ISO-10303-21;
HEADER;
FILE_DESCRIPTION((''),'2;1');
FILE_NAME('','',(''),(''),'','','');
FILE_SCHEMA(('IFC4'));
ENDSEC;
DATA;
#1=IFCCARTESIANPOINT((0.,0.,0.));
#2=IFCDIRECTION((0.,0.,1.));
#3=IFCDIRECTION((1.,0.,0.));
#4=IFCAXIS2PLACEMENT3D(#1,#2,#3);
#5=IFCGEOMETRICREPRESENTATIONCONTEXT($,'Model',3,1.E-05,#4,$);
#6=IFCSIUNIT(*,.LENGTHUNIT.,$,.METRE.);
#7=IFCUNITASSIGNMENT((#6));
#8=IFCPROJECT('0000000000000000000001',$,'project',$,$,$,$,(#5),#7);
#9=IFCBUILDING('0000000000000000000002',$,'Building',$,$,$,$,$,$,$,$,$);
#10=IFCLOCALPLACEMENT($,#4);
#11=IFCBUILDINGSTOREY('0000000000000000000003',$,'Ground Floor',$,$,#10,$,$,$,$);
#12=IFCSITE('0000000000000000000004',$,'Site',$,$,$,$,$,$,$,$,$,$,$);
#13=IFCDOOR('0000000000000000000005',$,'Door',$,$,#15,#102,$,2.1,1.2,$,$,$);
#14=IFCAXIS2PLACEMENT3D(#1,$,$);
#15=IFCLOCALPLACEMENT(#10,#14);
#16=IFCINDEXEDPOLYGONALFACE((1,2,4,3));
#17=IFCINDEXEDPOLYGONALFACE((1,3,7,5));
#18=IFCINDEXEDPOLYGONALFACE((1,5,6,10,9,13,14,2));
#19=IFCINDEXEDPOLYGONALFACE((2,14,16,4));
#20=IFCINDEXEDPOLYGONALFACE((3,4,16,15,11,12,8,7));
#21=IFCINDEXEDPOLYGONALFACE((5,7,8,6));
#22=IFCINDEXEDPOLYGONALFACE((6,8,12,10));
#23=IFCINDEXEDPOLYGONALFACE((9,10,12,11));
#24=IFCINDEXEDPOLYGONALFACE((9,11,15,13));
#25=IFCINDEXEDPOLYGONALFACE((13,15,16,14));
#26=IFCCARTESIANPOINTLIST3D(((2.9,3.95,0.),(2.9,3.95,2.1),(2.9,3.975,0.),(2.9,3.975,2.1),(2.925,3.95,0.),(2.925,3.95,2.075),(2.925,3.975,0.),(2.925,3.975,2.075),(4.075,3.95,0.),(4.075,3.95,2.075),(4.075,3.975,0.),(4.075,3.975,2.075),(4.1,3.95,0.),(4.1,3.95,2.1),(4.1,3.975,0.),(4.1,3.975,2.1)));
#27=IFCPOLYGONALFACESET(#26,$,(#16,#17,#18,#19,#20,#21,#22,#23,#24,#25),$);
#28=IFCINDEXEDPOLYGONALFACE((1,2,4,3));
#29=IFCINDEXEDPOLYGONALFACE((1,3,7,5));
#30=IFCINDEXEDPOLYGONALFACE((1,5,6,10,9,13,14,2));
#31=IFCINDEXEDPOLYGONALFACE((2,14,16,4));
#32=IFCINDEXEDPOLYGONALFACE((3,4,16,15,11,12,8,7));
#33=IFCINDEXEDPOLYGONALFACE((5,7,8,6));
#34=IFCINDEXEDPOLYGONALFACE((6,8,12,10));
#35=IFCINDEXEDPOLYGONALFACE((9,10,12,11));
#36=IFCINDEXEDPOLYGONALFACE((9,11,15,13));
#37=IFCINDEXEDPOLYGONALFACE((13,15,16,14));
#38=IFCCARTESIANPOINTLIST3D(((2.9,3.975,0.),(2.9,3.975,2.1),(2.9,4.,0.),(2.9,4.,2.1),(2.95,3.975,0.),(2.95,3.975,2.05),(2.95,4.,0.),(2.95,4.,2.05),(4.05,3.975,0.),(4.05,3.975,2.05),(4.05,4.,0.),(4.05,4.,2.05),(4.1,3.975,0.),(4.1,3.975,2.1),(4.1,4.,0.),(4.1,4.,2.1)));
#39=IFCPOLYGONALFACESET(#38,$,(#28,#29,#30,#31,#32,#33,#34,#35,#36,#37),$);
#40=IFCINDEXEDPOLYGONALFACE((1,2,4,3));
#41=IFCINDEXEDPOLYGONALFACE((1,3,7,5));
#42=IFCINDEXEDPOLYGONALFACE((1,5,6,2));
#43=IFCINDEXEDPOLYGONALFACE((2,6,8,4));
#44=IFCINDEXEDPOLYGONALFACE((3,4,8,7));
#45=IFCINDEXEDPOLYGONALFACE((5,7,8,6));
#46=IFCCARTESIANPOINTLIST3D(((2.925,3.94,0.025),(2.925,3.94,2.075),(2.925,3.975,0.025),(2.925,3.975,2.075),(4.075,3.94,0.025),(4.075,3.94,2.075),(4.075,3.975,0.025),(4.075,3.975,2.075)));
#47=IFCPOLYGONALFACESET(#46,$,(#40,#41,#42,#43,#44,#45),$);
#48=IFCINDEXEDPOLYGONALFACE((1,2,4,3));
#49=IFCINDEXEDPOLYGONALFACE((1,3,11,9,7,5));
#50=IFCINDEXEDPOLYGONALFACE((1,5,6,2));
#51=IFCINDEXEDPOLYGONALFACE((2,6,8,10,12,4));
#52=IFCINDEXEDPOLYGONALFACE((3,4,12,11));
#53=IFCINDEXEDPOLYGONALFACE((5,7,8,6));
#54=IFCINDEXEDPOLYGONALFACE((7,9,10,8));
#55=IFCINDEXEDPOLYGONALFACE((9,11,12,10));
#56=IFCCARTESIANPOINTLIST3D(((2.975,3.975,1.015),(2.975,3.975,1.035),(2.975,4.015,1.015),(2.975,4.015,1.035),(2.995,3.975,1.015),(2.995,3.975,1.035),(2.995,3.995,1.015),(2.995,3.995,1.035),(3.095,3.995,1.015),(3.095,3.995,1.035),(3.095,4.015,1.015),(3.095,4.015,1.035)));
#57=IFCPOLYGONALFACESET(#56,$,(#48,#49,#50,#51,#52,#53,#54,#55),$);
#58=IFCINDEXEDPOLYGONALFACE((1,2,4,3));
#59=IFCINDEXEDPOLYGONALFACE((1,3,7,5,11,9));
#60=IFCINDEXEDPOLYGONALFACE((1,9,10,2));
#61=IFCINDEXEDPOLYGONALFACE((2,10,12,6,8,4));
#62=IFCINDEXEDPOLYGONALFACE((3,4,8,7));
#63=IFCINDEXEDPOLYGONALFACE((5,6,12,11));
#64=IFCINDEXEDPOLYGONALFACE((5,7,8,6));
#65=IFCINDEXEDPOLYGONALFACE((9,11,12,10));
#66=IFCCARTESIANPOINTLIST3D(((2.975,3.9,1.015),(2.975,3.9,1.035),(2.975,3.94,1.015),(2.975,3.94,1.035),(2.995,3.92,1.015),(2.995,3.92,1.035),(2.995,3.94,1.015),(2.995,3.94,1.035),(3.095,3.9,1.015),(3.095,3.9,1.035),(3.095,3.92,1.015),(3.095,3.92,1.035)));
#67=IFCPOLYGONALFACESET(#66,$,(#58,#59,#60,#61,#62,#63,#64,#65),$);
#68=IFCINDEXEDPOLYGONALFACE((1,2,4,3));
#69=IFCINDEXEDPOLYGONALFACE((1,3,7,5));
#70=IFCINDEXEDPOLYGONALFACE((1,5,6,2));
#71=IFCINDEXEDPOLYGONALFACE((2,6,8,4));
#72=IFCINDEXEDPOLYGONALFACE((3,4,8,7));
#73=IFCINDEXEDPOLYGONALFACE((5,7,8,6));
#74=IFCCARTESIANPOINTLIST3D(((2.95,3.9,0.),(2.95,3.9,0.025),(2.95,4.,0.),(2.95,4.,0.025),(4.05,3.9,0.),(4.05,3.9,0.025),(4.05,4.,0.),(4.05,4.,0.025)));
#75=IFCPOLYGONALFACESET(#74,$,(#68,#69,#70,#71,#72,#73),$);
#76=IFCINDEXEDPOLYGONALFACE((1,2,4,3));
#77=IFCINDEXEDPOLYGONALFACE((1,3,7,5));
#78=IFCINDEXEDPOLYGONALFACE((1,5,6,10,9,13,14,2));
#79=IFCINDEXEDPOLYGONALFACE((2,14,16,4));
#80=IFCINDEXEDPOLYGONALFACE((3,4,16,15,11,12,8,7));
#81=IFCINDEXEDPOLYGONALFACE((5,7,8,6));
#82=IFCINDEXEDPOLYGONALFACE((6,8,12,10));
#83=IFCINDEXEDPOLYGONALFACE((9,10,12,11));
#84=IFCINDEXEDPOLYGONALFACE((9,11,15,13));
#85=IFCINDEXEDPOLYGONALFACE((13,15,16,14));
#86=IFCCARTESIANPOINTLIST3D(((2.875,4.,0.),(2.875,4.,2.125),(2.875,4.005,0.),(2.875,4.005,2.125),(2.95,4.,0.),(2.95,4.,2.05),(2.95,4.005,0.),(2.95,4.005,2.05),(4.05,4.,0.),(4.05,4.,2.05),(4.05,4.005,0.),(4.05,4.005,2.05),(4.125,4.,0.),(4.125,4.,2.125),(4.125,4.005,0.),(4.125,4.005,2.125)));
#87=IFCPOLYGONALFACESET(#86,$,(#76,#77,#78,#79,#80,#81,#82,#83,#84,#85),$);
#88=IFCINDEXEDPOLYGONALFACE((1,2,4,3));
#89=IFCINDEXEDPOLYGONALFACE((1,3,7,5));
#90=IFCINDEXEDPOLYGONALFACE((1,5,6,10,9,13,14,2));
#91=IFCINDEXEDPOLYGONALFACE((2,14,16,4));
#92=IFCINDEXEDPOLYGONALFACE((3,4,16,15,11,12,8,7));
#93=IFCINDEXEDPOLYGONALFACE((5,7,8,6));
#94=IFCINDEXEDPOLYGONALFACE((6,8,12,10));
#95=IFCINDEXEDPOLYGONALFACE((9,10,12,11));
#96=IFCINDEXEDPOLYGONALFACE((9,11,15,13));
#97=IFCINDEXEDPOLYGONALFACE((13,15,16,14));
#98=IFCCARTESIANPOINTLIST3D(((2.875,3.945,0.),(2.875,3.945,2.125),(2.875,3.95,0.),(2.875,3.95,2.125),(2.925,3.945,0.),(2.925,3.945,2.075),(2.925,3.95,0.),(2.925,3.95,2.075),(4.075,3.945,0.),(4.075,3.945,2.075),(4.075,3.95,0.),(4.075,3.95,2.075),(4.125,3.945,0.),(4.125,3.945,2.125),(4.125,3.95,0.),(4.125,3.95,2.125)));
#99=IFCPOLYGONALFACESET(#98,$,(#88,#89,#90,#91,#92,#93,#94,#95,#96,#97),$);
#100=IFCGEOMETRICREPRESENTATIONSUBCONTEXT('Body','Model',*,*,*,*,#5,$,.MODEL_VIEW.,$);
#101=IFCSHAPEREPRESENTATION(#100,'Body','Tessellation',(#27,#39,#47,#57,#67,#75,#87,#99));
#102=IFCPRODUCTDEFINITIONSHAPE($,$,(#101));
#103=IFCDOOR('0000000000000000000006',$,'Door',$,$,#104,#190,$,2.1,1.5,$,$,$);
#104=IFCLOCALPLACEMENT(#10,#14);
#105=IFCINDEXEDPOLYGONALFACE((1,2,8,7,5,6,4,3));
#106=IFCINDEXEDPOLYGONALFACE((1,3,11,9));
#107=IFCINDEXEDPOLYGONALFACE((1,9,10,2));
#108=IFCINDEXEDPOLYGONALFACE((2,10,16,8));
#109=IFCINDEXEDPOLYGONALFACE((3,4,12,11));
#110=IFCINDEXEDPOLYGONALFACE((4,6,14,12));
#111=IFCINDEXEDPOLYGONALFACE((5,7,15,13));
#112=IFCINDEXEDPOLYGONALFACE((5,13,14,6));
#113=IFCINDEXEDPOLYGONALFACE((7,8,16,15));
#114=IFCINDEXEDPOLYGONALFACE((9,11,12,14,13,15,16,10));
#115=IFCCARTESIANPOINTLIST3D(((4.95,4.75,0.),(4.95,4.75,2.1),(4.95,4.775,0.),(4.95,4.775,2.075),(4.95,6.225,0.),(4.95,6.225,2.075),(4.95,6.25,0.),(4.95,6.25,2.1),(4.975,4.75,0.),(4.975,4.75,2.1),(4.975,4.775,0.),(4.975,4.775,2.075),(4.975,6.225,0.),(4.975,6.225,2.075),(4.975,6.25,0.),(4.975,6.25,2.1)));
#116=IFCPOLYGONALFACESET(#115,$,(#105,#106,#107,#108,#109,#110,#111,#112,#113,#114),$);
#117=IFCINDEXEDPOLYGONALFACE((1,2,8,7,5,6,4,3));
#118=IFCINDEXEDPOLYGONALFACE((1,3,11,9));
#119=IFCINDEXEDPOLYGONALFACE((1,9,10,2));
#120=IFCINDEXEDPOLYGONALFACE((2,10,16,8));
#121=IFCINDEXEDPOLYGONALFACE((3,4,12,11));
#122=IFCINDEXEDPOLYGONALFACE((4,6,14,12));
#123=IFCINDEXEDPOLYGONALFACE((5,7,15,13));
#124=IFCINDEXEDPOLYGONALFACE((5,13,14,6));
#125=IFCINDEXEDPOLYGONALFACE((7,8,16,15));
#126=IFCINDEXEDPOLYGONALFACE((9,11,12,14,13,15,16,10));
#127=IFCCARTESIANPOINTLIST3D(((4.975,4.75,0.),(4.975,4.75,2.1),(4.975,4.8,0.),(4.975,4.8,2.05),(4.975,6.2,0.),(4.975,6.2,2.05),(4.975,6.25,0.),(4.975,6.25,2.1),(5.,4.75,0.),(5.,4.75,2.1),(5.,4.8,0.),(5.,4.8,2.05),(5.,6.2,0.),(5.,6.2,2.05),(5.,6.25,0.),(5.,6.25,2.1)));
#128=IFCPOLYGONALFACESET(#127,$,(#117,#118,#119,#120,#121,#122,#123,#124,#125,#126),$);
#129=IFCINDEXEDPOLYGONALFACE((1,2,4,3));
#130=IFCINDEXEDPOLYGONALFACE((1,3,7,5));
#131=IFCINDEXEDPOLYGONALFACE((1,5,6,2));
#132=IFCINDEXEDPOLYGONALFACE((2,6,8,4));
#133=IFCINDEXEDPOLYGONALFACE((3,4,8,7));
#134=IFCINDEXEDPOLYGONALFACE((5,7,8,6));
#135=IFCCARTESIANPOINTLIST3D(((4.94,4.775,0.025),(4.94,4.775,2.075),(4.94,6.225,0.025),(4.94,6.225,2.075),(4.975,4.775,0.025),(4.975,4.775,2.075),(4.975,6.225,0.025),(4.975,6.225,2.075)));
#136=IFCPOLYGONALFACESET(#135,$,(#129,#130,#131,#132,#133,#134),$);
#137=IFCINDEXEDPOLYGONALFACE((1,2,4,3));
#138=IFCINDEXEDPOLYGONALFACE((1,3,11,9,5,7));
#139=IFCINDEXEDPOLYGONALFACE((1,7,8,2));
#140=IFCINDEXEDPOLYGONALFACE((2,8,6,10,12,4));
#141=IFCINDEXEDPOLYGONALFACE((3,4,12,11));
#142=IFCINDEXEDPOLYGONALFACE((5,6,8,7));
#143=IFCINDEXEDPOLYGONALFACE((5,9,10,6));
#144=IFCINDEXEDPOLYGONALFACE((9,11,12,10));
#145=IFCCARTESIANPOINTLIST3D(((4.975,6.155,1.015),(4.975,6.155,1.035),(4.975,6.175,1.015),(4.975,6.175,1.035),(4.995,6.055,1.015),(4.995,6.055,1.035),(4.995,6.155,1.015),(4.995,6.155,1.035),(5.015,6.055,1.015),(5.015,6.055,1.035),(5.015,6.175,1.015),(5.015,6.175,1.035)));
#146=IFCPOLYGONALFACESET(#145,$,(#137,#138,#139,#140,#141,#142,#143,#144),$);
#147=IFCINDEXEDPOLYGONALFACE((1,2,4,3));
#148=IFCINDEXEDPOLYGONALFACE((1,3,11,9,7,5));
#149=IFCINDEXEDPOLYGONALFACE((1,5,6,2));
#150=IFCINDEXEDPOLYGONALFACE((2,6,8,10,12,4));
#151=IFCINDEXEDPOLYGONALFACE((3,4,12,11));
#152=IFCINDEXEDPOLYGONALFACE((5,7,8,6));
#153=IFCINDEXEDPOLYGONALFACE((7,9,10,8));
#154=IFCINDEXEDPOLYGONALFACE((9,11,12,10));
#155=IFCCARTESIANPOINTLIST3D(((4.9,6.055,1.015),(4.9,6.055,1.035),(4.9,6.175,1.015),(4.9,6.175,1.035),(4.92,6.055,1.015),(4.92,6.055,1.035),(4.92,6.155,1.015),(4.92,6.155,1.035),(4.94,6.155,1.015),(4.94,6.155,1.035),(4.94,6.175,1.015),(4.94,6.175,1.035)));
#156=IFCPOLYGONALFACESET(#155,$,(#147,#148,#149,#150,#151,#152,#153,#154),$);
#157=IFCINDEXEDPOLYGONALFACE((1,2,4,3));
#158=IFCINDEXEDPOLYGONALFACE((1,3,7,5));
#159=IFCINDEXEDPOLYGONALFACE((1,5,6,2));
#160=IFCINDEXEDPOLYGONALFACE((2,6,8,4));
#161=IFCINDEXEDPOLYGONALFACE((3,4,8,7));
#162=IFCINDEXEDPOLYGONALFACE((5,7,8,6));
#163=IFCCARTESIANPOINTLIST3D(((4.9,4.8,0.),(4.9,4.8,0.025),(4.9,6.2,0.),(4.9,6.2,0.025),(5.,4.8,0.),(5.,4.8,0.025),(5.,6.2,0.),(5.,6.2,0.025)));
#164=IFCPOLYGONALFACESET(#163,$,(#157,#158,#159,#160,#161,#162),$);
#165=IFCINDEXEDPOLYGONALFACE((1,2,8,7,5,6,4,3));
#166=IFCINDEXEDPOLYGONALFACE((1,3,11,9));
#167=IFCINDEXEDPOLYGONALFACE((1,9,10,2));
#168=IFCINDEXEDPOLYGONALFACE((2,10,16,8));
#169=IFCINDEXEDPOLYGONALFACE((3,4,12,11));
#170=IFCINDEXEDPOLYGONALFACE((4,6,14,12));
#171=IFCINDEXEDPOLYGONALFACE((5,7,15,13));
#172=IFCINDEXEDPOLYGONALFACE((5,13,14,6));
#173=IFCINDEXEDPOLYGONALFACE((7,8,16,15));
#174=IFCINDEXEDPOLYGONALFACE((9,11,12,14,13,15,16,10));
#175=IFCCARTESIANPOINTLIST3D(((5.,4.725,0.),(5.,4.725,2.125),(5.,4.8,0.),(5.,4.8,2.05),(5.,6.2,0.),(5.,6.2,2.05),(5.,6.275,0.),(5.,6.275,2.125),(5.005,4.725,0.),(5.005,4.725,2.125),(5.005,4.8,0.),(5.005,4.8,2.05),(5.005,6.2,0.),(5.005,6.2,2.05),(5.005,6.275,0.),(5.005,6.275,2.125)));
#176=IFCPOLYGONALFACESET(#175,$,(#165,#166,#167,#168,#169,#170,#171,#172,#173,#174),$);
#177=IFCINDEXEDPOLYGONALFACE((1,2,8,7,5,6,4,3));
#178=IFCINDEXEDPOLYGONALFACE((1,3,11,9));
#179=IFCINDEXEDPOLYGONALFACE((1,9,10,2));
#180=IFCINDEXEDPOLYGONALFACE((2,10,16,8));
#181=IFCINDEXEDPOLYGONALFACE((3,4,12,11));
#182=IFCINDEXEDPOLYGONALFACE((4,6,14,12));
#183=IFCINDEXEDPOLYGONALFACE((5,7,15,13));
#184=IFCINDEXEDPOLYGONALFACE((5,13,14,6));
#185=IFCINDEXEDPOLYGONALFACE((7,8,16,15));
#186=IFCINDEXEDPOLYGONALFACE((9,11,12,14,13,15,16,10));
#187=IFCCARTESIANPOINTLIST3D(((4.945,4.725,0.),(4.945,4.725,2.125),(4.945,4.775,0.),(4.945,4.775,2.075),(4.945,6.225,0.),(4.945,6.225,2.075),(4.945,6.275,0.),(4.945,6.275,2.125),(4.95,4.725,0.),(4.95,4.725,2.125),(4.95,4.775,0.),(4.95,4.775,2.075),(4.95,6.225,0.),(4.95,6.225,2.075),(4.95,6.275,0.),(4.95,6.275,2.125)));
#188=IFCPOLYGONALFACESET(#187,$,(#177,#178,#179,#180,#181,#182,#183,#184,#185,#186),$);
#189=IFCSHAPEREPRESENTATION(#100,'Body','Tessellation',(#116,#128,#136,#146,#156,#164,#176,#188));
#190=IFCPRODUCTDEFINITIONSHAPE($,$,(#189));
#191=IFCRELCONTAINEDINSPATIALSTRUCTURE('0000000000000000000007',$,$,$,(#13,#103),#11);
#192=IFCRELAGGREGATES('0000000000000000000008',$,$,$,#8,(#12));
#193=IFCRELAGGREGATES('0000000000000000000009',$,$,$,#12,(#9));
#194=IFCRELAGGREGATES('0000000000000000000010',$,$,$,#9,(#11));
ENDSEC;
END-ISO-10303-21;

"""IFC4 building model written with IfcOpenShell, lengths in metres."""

from ifc_helpers import new_model, si_unit, frame, origin_with_axes, place, context, subcontext, project, spatial, line, indexed_curve, outline, extrude, element, save


model = new_model("IFC4")

# Units and contexts
model_context = context("Model", 3, precision=1e-05, world=origin_with_axes())
body_context = subcontext(model_context, "Body", "Model", "MODEL_VIEW")
ifc_project = project(units=[si_unit("LENGTHUNIT", "METRE")], contexts=[model_context])

# Site, building, storey
site = spatial("IfcSite", under=ifc_project, Name="Site")
building = spatial("IfcBuilding", under=site, Name="Building")
storey_placement = place(None, origin_with_axes())
storey = spatial("IfcBuildingStorey", under=building, at=storey_placement, Name="Ground Floor")

# Doors
door_1_placement = place(storey_placement, frame((4.1, 4.0, 0.0), z_axis=(0.0, 0.0, 1.0), x_axis=(-1.0, 0.0, 0.0)))
element("IfcDoor", 1, at=door_1_placement, inside=storey, Name="Door", OverallHeight=2.1, OverallWidth=1.2, context=body_context, shape_type="SweptSolid", body=[
    extrude(outline(indexed_curve([(0.0, 0.0), (0.0, 2.1), (1.2, 2.1), (1.2, 0.0), (1.175, 0.0), (1.175, 2.075), (0.025, 2.075), (0.025, 0.0)], segments=[line(1, 2, 3, 4, 5, 6, 7, 8, 1)])), frame((0.0, 0.025, 0.0), z_axis=(0.0, -1.0, 0.0), x_axis=(1.0, 0.0, 0.0)), (0.0, 0.0, -1.0), 0.025),
    extrude(outline(indexed_curve([(0.0, 0.0), (0.0, 2.1), (1.2, 2.1), (1.2, 0.0), (1.15, 0.0), (1.15, 2.05), (0.05, 2.05), (0.05, 0.0)], segments=[line(1, 2, 3, 4, 5, 6, 7, 8, 1)])), frame((0.0, 0.0, 0.0), z_axis=(0.0, -1.0, 0.0), x_axis=(1.0, 0.0, 0.0)), (0.0, 0.0, -1.0), 0.025),
    extrude(outline(indexed_curve([(0.0, 0.0), (1.15, 0.0), (1.15, 0.035), (0.0, 0.035)], segments=[line(1, 2, 3, 4, 1)])), frame((0.025, 0.025, 0.025), z_axis=(0.0, 0.0, 1.0), x_axis=(1.0, 0.0, 0.0)), (0.0, 0.0, 1.0), 2.05),
    extrude(outline(indexed_curve([(0.0, 0.0), (0.0, -0.04), (-0.12, -0.04), (-0.12, -0.02), (-0.02, -0.02), (-0.02, 0.0)], segments=[line(1, 2, 3, 4, 5, 6, 1)])), frame((1.125, 0.025, 1.015), z_axis=(0.0, 0.0, 1.0), x_axis=(1.0, 0.0, 0.0)), (0.0, 0.0, 1.0), 0.02),
    extrude(outline(indexed_curve([(0.0, 0.0), (0.0, 0.04), (-0.12, 0.04), (-0.12, 0.02), (-0.02, 0.02), (-0.02, 0.0)], segments=[line(1, 2, 3, 4, 5, 6, 1)])), frame((1.125, 0.06, 1.015), z_axis=(0.0, 0.0, 1.0), x_axis=(1.0, 0.0, 0.0)), (0.0, 0.0, 1.0), 0.02),
    extrude(outline(indexed_curve([(0.0, 0.0), (1.1, 0.0), (1.1, 0.1), (0.0, 0.1)], segments=[line(1, 2, 3, 4, 1)])), frame((0.05, 0.0, 0.0), z_axis=(0.0, 0.0, 1.0), x_axis=(1.0, 0.0, 0.0)), (0.0, 0.0, 1.0), 0.025),
    extrude(outline(indexed_curve([(0.0, 0.0), (0.0, 2.125), (1.25, 2.125), (1.25, 0.0), (1.175, 0.0), (1.175, 2.05), (0.075, 2.05), (0.075, 0.0)], segments=[line(1, 2, 3, 4, 5, 6, 7, 8, 1)])), frame((-0.025, -0.005, 0.0), z_axis=(0.0, -1.0, 0.0), x_axis=(1.0, 0.0, 0.0)), (0.0, 0.0, -1.0), 0.005),
    extrude(outline(indexed_curve([(0.0, 0.0), (0.0, 2.125), (1.25, 2.125), (1.25, 0.0), (1.2, 0.0), (1.2, 2.075), (0.05, 2.075), (0.05, 0.0)], segments=[line(1, 2, 3, 4, 5, 6, 7, 8, 1)])), frame((-0.025, 0.05, 0.0), z_axis=(0.0, -1.0, 0.0), x_axis=(1.0, 0.0, 0.0)), (0.0, 0.0, -1.0), 0.005),
])
door_2_placement = place(storey_placement, frame((5.0, 4.75, 0.0), z_axis=(0.0, 0.0, 1.0), x_axis=(0.0, 1.0, 0.0)))
element("IfcDoor", 2, at=door_2_placement, inside=storey, Name="Door", OverallHeight=2.1, OverallWidth=1.5, context=body_context, shape_type="SweptSolid", body=[
    extrude(outline(indexed_curve([(0.0, 0.0), (0.0, 2.1), (1.5, 2.1), (1.5, 0.0), (1.475, 0.0), (1.475, 2.075), (0.025, 2.075), (0.025, 0.0)], segments=[line(1, 2, 3, 4, 5, 6, 7, 8, 1)])), frame((0.0, 0.025, 0.0), z_axis=(0.0, -1.0, 0.0), x_axis=(1.0, 0.0, 0.0)), (0.0, 0.0, -1.0), 0.025),
    extrude(outline(indexed_curve([(0.0, 0.0), (0.0, 2.1), (1.5, 2.1), (1.5, 0.0), (1.45, 0.0), (1.45, 2.05), (0.05, 2.05), (0.05, 0.0)], segments=[line(1, 2, 3, 4, 5, 6, 7, 8, 1)])), frame((0.0, 0.0, 0.0), z_axis=(0.0, -1.0, 0.0), x_axis=(1.0, 0.0, 0.0)), (0.0, 0.0, -1.0), 0.025),
    extrude(outline(indexed_curve([(0.0, 0.0), (1.45, 0.0), (1.45, 0.035), (0.0, 0.035)], segments=[line(1, 2, 3, 4, 1)])), frame((0.025, 0.025, 0.025), z_axis=(0.0, 0.0, 1.0), x_axis=(1.0, 0.0, 0.0)), (0.0, 0.0, 1.0), 2.05),
    extrude(outline(indexed_curve([(0.0, 0.0), (0.0, -0.04), (-0.12, -0.04), (-0.12, -0.02), (-0.02, -0.02), (-0.02, 0.0)], segments=[line(1, 2, 3, 4, 5, 6, 1)])), frame((1.425, 0.025, 1.015), z_axis=(0.0, 0.0, 1.0), x_axis=(1.0, 0.0, 0.0)), (0.0, 0.0, 1.0), 0.02),
    extrude(outline(indexed_curve([(0.0, 0.0), (0.0, 0.04), (-0.12, 0.04), (-0.12, 0.02), (-0.02, 0.02), (-0.02, 0.0)], segments=[line(1, 2, 3, 4, 5, 6, 1)])), frame((1.425, 0.06, 1.015), z_axis=(0.0, 0.0, 1.0), x_axis=(1.0, 0.0, 0.0)), (0.0, 0.0, 1.0), 0.02),
    extrude(outline(indexed_curve([(0.0, 0.0), (1.4, 0.0), (1.4, 0.1), (0.0, 0.1)], segments=[line(1, 2, 3, 4, 1)])), frame((0.05, 0.0, 0.0), z_axis=(0.0, 0.0, 1.0), x_axis=(1.0, 0.0, 0.0)), (0.0, 0.0, 1.0), 0.025),
    extrude(outline(indexed_curve([(0.0, 0.0), (0.0, 2.125), (1.55, 2.125), (1.55, 0.0), (1.475, 0.0), (1.475, 2.05), (0.075, 2.05), (0.075, 0.0)], segments=[line(1, 2, 3, 4, 5, 6, 7, 8, 1)])), frame((-0.025, -0.005, 0.0), z_axis=(0.0, -1.0, 0.0), x_axis=(1.0, 0.0, 0.0)), (0.0, 0.0, -1.0), 0.005),
    extrude(outline(indexed_curve([(0.0, 0.0), (0.0, 2.125), (1.55, 2.125), (1.55, 0.0), (1.5, 0.0), (1.5, 2.075), (0.05, 2.075), (0.05, 0.0)], segments=[line(1, 2, 3, 4, 5, 6, 7, 8, 1)])), frame((-0.025, 0.05, 0.0), z_axis=(0.0, -1.0, 0.0), x_axis=(1.0, 0.0, 0.0)), (0.0, 0.0, -1.0), 0.005),
])

save(model, "model.ifc")
